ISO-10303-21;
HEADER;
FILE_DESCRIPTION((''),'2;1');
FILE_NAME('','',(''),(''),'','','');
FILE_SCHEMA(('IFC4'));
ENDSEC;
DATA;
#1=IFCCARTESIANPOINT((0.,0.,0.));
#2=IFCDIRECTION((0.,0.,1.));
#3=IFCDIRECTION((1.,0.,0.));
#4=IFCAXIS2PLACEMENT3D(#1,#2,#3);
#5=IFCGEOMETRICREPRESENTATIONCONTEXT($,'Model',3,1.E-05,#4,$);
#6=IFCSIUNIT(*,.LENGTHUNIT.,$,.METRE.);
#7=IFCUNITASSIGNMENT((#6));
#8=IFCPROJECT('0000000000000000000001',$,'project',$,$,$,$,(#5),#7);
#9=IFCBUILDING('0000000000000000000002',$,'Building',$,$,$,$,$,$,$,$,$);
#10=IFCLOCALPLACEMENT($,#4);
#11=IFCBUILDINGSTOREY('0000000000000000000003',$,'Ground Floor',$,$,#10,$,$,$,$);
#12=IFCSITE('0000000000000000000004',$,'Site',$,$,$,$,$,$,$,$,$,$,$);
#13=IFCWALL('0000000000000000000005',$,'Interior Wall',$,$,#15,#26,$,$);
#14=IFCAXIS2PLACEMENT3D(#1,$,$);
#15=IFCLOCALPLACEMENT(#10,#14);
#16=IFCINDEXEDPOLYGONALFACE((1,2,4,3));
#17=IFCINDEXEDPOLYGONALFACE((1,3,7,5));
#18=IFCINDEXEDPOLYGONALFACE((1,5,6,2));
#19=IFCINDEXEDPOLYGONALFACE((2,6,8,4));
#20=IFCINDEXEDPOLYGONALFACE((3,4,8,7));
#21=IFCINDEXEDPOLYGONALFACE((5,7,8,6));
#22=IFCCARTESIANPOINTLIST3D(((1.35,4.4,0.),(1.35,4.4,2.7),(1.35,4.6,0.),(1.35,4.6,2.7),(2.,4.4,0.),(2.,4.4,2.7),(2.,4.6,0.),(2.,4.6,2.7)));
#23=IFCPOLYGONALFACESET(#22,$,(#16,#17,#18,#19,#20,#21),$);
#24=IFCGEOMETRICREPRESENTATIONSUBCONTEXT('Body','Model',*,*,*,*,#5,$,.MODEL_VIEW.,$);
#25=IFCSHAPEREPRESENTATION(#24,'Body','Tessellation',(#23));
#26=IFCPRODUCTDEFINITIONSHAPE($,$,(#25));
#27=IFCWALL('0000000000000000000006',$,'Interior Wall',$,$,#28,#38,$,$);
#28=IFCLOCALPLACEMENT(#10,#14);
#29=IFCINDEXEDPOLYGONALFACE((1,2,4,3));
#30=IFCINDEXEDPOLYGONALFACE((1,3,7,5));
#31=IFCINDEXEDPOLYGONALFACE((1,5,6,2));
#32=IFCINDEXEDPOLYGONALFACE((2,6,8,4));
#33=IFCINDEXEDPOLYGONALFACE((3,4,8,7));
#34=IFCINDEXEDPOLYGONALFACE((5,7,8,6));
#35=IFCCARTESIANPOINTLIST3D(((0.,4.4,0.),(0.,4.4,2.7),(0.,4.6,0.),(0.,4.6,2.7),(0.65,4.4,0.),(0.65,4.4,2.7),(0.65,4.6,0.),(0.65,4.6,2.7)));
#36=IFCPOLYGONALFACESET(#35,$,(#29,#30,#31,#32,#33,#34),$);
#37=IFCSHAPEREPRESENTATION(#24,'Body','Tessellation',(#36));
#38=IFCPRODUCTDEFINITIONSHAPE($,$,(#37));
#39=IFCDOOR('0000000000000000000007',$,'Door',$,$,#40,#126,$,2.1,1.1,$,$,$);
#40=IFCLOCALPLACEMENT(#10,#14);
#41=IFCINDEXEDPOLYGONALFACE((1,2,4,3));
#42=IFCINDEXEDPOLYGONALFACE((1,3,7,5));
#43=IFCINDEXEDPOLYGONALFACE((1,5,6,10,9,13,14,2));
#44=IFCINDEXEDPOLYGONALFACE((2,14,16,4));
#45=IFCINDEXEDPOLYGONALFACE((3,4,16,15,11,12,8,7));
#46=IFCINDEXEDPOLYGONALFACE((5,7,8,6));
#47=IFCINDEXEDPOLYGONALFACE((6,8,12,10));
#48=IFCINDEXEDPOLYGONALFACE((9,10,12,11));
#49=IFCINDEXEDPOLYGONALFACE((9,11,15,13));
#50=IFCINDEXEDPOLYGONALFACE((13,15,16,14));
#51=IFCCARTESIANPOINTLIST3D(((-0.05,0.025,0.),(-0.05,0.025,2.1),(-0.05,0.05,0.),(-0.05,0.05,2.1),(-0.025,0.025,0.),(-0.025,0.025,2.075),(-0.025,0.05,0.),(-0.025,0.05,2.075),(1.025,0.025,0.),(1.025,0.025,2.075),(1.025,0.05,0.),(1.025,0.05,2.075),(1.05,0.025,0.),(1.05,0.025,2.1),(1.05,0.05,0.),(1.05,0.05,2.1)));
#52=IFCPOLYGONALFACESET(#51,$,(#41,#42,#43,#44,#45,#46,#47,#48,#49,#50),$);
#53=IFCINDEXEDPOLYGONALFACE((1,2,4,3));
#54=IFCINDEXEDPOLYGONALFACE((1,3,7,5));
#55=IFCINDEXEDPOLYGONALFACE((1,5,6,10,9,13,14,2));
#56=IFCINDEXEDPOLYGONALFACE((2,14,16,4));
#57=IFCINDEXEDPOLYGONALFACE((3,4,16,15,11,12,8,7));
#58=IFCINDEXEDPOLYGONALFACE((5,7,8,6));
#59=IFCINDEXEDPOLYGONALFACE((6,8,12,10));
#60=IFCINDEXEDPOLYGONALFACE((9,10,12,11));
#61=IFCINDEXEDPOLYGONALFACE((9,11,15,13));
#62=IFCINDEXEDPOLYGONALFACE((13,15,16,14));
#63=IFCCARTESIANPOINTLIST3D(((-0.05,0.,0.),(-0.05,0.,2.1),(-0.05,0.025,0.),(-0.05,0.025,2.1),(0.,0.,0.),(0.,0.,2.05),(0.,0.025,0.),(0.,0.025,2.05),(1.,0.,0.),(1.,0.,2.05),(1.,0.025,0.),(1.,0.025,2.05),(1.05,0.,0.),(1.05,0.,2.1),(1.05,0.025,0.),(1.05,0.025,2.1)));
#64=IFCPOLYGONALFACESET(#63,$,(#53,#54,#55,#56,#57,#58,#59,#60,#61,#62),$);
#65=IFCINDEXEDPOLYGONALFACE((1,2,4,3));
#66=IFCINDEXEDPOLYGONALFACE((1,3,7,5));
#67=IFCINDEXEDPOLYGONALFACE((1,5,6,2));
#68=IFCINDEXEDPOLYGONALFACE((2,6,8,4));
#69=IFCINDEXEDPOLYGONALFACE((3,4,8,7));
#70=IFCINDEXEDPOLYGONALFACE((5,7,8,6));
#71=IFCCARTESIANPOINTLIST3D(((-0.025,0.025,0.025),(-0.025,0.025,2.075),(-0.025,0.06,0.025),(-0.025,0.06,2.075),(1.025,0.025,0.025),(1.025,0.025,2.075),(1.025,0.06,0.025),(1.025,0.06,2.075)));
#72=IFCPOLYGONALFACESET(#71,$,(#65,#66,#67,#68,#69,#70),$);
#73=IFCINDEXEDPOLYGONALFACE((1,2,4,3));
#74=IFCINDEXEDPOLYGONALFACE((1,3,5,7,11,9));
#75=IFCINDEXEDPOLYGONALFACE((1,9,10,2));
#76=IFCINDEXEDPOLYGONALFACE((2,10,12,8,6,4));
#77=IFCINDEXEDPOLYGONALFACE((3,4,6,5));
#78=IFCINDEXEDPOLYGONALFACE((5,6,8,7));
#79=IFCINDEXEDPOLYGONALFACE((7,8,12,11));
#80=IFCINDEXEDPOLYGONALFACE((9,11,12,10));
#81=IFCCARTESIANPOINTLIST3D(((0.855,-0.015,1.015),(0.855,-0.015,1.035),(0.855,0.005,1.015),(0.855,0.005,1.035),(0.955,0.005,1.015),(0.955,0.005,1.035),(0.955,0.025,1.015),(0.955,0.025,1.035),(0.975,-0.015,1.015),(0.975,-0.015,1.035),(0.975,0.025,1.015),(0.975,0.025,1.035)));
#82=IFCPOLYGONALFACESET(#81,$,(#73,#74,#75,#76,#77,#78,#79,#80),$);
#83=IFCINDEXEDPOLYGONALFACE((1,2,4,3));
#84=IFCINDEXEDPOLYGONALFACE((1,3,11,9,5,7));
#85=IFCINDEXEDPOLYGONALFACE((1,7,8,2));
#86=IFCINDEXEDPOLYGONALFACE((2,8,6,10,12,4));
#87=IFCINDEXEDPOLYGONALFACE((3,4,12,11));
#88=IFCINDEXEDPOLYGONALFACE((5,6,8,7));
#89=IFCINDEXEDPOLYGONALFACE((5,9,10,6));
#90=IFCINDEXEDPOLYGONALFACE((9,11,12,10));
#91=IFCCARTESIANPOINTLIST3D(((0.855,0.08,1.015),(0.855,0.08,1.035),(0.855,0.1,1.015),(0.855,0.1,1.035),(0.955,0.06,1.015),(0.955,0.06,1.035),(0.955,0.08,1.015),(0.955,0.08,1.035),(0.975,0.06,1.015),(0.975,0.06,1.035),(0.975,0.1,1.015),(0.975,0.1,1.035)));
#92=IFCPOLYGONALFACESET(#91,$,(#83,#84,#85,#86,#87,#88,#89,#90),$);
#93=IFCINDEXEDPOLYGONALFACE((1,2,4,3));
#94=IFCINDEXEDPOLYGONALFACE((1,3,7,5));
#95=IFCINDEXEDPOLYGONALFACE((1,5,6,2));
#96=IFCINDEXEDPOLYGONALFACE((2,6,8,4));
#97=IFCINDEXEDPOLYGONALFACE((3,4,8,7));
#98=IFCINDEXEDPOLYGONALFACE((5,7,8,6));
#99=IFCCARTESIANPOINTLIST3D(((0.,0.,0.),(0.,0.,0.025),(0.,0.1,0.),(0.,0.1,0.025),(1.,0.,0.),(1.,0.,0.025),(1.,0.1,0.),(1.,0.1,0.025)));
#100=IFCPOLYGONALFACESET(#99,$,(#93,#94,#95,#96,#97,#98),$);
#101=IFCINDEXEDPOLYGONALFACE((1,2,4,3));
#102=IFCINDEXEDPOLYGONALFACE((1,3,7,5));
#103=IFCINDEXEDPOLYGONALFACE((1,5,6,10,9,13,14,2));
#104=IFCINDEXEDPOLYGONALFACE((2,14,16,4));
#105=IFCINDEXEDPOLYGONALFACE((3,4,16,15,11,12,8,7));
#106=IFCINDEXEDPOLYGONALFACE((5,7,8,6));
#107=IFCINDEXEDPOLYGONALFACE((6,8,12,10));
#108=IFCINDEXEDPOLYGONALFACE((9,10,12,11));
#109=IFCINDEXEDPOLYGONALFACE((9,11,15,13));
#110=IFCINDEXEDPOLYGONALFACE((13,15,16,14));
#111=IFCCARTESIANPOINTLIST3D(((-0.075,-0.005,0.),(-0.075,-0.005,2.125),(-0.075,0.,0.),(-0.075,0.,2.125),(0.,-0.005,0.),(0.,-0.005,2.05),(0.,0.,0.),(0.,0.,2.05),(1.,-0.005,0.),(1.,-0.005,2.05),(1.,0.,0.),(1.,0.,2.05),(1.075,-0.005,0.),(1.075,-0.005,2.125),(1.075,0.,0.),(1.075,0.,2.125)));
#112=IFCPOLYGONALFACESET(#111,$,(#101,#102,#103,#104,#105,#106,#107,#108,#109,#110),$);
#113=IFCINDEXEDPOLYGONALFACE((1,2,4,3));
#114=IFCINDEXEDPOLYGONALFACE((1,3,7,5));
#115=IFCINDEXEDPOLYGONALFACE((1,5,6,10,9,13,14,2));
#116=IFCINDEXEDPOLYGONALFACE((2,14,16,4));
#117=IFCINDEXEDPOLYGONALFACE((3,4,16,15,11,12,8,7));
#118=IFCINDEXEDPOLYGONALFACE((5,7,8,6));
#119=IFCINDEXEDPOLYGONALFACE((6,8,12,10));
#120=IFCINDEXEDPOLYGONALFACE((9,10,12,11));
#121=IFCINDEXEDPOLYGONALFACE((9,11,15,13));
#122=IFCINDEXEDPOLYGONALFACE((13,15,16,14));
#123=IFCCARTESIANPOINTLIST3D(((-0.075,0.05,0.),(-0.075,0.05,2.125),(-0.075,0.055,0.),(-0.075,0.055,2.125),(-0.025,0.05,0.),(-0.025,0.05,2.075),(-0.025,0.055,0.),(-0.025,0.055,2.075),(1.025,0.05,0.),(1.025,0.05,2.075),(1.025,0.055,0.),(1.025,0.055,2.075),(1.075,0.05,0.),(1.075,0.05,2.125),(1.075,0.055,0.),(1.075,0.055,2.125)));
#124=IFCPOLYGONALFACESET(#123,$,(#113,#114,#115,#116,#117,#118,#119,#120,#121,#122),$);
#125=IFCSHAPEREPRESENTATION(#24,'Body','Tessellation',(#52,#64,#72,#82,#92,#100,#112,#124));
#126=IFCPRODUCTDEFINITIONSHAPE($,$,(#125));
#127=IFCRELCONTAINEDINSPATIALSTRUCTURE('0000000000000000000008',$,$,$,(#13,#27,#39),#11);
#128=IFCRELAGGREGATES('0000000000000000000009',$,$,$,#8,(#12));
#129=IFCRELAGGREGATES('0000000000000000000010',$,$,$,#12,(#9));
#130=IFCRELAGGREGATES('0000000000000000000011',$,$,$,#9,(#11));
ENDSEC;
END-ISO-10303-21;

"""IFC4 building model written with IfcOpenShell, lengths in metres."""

from ifc_helpers import new_model, si_unit, frame, origin_with_axes, place, context, subcontext, project, spatial, line, indexed_curve, outline, extrude, element, save


model = new_model("IFC4")

# Units and contexts
model_context = context("Model", 3, precision=1e-05, world=origin_with_axes())
body_context = subcontext(model_context, "Body", "Model", "MODEL_VIEW")
ifc_project = project(units=[si_unit("LENGTHUNIT", "METRE")], contexts=[model_context])

# Site, building, storey
site = spatial("IfcSite", under=ifc_project, Name="Site")
building = spatial("IfcBuilding", under=site, Name="Building")
storey_placement = place(None, origin_with_axes())
storey = spatial("IfcBuildingStorey", under=building, at=storey_placement, Name="Ground Floor")

# Walls
for number, where, z_axis, x_axis, name in (
    (1, (2.0, 4.5, 0.0), (0.0, 0.0, 1.0), (-1.0, 0.0, 0.0), "Interior Wall"),
    (2, (0.65, 4.5, 0.0), (0.0, 0.0, 1.0), (-1.0, 0.0, 0.0), "Interior Wall"),
):
    element("IfcWall", number, at=place(storey_placement, frame(where, z_axis=z_axis, x_axis=x_axis)), inside=storey, Name=name, context=body_context, shape_type="SweptSolid", body=[
        extrude(outline(indexed_curve([(0.0, 0.0), (0.0, 0.2), (0.65, 0.2), (0.65, 0.0), (0.0, 0.0)], self_intersect=False)), frame((0.0, -0.1, 0.0), z_axis=(0.0, 0.0, 1.0), x_axis=(1.0, 0.0, 0.0)), (0.0, 0.0, 1.0), 2.7),
    ])

# Door
door_1_placement = place(storey_placement, frame((-0.05, 0.0, 0.0), z_axis=(0.0, 0.0, 1.0), x_axis=(1.0, 0.0, 0.0)))
element("IfcDoor", 3, at=door_1_placement, inside=storey, Name="Door", OverallHeight=2.1, OverallWidth=1.1, context=body_context, shape_type="SweptSolid", body=[
    extrude(outline(indexed_curve([(0.0, 0.0), (0.0, 2.1), (1.1, 2.1), (1.1, 0.0), (1.075, 0.0), (1.075, 2.075), (0.025, 2.075), (0.025, 0.0)], segments=[line(1, 2, 3, 4, 5, 6, 7, 8, 1)])), frame((0.0, 0.025, 0.0), z_axis=(0.0, -1.0, 0.0), x_axis=(1.0, 0.0, 0.0)), (0.0, 0.0, -1.0), 0.025),
    extrude(outline(indexed_curve([(0.0, 0.0), (0.0, 2.1), (1.1, 2.1), (1.1, 0.0), (1.05, 0.0), (1.05, 2.05), (0.05, 2.05), (0.05, 0.0)], segments=[line(1, 2, 3, 4, 5, 6, 7, 8, 1)])), frame((0.0, 0.0, 0.0), z_axis=(0.0, -1.0, 0.0), x_axis=(1.0, 0.0, 0.0)), (0.0, 0.0, -1.0), 0.025),
    extrude(outline(indexed_curve([(0.0, 0.0), (1.05, 0.0), (1.05, 0.035), (0.0, 0.035)], segments=[line(1, 2, 3, 4, 1)])), frame((0.025, 0.025, 0.025), z_axis=(0.0, 0.0, 1.0), x_axis=(1.0, 0.0, 0.0)), (0.0, 0.0, 1.0), 2.05),
    extrude(outline(indexed_curve([(0.0, 0.0), (0.0, -0.04), (-0.12, -0.04), (-0.12, -0.02), (-0.02, -0.02), (-0.02, 0.0)], segments=[line(1, 2, 3, 4, 5, 6, 1)])), frame((1.025, 0.025, 1.015), z_axis=(0.0, 0.0, 1.0), x_axis=(1.0, 0.0, 0.0)), (0.0, 0.0, 1.0), 0.02),
    extrude(outline(indexed_curve([(0.0, 0.0), (0.0, 0.04), (-0.12, 0.04), (-0.12, 0.02), (-0.02, 0.02), (-0.02, 0.0)], segments=[line(1, 2, 3, 4, 5, 6, 1)])), frame((1.025, 0.06, 1.015), z_axis=(0.0, 0.0, 1.0), x_axis=(1.0, 0.0, 0.0)), (0.0, 0.0, 1.0), 0.02),
    extrude(outline(indexed_curve([(0.0, 0.0), (1.0, 0.0), (1.0, 0.1), (0.0, 0.1)], segments=[line(1, 2, 3, 4, 1)])), frame((0.05, 0.0, 0.0), z_axis=(0.0, 0.0, 1.0), x_axis=(1.0, 0.0, 0.0)), (0.0, 0.0, 1.0), 0.025),
    extrude(outline(indexed_curve([(0.0, 0.0), (0.0, 2.125), (1.15, 2.125), (1.15, 0.0), (1.075, 0.0), (1.075, 2.05), (0.075, 2.05), (0.075, 0.0)], segments=[line(1, 2, 3, 4, 5, 6, 7, 8, 1)])), frame((-0.025, -0.005, 0.0), z_axis=(0.0, -1.0, 0.0), x_axis=(1.0, 0.0, 0.0)), (0.0, 0.0, -1.0), 0.005),
    extrude(outline(indexed_curve([(0.0, 0.0), (0.0, 2.125), (1.15, 2.125), (1.15, 0.0), (1.1, 0.0), (1.1, 2.075), (0.05, 2.075), (0.05, 0.0)], segments=[line(1, 2, 3, 4, 5, 6, 7, 8, 1)])), frame((-0.025, 0.05, 0.0), z_axis=(0.0, -1.0, 0.0), x_axis=(1.0, 0.0, 0.0)), (0.0, 0.0, -1.0), 0.005),
])

save(model, "model.ifc")
